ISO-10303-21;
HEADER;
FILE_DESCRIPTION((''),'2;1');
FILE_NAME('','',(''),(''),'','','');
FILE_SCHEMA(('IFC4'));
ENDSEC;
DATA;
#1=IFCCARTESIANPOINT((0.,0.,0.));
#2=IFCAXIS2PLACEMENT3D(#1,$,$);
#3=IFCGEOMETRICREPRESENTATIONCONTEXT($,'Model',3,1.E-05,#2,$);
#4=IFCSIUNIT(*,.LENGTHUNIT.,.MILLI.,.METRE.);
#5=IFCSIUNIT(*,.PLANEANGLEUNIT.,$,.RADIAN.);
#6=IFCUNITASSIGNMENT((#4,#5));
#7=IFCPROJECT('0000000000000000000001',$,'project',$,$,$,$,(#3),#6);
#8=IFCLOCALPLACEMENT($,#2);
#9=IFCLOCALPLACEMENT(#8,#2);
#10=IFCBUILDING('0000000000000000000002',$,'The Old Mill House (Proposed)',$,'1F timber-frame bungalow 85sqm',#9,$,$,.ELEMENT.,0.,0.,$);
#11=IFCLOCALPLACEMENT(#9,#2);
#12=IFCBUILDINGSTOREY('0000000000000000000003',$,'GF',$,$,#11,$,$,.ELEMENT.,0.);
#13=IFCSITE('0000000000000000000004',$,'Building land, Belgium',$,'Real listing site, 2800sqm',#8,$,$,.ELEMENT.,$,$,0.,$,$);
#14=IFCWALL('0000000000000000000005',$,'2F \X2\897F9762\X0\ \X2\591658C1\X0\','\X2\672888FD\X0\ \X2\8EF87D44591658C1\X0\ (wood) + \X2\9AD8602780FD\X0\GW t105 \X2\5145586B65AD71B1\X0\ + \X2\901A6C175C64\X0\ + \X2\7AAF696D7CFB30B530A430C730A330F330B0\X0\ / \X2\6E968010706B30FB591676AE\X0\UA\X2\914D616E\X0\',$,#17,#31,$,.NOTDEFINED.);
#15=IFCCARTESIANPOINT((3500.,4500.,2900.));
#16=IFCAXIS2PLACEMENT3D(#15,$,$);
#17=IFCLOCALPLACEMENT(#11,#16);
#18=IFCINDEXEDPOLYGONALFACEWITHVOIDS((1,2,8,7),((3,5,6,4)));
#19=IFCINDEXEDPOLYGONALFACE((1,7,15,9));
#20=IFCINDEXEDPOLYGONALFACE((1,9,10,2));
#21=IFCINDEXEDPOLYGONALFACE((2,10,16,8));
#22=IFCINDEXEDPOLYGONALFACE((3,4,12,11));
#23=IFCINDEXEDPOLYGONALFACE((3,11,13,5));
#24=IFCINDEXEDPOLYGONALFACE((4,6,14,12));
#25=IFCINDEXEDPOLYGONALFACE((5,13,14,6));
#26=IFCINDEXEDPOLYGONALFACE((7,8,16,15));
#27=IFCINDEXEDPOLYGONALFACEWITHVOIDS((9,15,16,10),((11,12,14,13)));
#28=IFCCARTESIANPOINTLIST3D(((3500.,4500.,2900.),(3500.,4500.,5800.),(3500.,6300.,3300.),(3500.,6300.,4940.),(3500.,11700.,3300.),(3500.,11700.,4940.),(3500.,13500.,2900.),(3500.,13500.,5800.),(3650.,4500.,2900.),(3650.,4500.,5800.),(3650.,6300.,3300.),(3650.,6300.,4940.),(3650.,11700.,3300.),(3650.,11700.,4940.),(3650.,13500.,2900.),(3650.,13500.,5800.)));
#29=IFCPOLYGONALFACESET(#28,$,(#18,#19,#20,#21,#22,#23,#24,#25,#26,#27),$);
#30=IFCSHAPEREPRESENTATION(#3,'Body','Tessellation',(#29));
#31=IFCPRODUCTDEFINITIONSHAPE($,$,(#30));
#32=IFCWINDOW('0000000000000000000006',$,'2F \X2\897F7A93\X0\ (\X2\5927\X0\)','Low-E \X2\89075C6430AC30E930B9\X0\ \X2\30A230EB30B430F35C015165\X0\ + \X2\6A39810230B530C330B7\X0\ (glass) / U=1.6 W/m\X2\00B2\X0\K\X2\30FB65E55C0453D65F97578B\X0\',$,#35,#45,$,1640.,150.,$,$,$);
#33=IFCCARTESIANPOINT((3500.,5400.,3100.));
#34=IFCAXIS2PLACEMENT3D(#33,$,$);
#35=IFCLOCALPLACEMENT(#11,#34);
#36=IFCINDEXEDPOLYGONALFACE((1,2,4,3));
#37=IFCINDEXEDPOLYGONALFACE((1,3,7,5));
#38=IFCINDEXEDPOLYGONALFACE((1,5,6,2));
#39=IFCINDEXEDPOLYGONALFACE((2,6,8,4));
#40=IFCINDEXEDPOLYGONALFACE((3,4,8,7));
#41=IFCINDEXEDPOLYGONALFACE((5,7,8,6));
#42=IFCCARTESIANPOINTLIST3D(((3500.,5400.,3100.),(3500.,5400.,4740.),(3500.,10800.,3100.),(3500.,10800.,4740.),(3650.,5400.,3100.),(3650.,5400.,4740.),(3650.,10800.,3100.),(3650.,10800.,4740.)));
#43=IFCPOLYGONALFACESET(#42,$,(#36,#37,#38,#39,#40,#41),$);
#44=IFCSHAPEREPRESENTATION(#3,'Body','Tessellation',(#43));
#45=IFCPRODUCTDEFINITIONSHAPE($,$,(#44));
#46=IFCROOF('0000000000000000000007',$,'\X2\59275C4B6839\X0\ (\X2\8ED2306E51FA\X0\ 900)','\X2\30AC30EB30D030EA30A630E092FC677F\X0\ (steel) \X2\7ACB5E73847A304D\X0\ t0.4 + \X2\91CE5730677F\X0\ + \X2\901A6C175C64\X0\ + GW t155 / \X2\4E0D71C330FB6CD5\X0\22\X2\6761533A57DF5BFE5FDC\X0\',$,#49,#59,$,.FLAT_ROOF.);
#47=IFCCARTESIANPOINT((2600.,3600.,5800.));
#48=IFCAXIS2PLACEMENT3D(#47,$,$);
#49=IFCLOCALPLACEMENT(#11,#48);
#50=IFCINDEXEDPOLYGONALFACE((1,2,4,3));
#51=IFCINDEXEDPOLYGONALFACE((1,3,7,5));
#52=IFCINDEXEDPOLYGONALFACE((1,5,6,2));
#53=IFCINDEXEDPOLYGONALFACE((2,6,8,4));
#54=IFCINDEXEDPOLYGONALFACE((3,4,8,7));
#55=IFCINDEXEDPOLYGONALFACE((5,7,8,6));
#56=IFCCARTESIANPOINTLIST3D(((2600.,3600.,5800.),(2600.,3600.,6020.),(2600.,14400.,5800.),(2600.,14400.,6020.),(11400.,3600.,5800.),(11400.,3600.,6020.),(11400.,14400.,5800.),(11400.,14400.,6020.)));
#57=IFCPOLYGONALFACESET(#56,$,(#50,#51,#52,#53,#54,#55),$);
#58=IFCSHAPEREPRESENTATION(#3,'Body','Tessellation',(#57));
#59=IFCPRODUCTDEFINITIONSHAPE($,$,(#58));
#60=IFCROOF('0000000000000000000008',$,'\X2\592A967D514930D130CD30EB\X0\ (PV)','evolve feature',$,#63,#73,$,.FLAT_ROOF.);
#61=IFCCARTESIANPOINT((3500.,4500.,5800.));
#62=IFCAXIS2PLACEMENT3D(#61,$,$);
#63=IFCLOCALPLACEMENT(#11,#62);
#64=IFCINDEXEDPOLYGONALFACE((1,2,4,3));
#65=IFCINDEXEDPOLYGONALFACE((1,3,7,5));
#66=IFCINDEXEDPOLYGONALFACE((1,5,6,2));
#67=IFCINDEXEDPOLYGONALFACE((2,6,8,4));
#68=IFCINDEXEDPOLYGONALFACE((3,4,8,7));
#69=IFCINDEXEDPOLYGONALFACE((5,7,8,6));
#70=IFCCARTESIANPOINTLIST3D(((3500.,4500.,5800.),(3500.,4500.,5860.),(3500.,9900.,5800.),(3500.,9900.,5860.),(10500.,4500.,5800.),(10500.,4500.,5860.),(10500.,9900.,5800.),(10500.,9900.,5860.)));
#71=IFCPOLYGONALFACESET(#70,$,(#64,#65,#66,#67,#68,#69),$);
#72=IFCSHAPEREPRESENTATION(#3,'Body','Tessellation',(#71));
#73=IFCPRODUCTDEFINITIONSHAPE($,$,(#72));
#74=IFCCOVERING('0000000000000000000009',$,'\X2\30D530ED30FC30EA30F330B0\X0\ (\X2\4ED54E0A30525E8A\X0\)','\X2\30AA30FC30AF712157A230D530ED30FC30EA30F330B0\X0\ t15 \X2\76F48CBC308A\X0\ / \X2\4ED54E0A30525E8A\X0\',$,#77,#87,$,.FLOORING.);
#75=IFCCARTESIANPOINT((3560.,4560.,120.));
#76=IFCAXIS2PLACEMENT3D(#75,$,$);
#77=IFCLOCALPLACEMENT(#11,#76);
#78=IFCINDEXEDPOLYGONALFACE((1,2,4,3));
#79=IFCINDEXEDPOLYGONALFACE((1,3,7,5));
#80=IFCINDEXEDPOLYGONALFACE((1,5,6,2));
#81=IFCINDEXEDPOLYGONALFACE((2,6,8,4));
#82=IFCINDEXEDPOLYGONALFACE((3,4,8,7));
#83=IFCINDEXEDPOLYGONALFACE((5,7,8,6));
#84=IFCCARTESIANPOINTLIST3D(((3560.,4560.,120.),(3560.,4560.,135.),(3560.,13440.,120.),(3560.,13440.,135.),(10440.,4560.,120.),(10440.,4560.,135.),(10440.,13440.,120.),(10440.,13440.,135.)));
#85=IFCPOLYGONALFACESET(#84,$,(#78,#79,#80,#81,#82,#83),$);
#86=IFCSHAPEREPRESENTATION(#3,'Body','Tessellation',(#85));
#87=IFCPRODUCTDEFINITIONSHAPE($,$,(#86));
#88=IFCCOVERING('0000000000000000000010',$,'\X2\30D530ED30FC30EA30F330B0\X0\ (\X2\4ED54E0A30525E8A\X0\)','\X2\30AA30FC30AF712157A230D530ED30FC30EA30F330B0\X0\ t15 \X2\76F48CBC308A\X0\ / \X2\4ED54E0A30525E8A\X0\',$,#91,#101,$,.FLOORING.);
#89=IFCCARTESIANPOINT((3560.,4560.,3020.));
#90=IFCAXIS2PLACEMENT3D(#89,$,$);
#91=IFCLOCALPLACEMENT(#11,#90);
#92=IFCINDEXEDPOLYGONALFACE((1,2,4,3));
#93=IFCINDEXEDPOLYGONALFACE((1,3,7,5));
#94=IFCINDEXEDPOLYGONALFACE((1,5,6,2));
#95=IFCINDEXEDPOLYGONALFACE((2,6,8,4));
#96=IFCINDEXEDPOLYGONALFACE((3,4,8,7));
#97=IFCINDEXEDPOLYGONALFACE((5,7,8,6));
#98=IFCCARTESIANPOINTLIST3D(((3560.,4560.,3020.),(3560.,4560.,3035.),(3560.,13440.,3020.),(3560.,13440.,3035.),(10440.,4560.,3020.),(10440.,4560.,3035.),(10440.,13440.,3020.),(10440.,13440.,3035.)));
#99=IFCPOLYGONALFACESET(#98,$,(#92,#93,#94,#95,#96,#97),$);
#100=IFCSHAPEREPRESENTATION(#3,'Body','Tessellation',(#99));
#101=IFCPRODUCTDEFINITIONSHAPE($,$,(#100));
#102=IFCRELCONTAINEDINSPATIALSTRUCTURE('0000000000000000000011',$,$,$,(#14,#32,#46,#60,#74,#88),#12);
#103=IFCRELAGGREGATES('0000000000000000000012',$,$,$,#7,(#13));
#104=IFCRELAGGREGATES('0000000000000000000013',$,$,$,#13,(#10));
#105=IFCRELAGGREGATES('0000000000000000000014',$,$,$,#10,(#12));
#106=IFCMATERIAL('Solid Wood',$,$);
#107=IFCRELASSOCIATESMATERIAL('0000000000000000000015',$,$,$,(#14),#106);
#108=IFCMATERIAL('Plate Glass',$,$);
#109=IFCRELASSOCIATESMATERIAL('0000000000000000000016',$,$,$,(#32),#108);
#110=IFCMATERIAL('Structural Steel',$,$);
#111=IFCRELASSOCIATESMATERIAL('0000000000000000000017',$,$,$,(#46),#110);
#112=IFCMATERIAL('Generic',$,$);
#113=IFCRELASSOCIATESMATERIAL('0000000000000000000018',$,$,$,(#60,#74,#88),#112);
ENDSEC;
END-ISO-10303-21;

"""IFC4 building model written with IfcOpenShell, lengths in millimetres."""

from ifc_helpers import new_model, si_unit, frame, frame_2d, origin, place, context, project, spatial, rectangle, extrude, material, element, fill, save


model = new_model("IFC4")

# Units and contexts
model_context = context("Model", 3, precision=1e-05, world=origin())
ifc_project = project(units=[si_unit("LENGTHUNIT", "METRE", prefix="MILLI"), si_unit("PLANEANGLEUNIT", "RADIAN")], contexts=[model_context])

# Site, building, storey
site_placement = place(None, origin())
site = spatial("IfcSite", under=ifc_project, at=site_placement, Name="Building land, Belgium", ObjectType="Real listing site, 2800sqm", CompositionType="ELEMENT", RefElevation=0.0)
building_placement = place(site_placement, origin())
building = spatial("IfcBuilding", under=site, at=building_placement, Name="The Old Mill House (Proposed)", ObjectType="1F timber-frame bungalow 85sqm", CompositionType="ELEMENT", ElevationOfRefHeight=0.0, ElevationOfTerrain=0.0)
storey_placement = place(building_placement, origin())
storey = spatial("IfcBuildingStorey", under=building, at=storey_placement, Name="GF", CompositionType="ELEMENT", Elevation=0.0)

# Shared definitions
ifc_material_1 = material(Name="Solid Wood")
ifc_material_2 = material(Name="Generic")

# Shared definitions
ifc_material_3 = material(Name="Plate Glass")

# Wall, opening, window
wall_1_placement = place(storey_placement, frame((3500.0, 4500.0, 2900.0)))
wall_1 = element("IfcWall", 1, at=wall_1_placement, inside=storey, material=ifc_material_1, Name="2F 西面 外壁", Description="木製 軸組外壁 (wood) + 高性能GW t105 充填断熱 + 通気層 + 窯業系サイディング / 準耐火・外皮UA配慮", PredefinedType="NOTDEFINED", context=model_context, shape_type="SweptSolid", body=[
    extrude(rectangle(XDim=150.0, YDim=9000.0, at=frame_2d((75.0, 4500.0))), frame((3500.0, 4500.0, 2900.0)), (0.0, 0.0, 1.0), 2900.0),
])
opening_1_placement = place(storey_placement, frame((3500.0, 5400.0, 3100.0)))
opening_1 = element("IfcOpeningElement", 2, at=opening_1_placement, cuts=wall_1, PredefinedType="NOTDEFINED", context=model_context, shape_type="SweptSolid", body=[
    extrude(rectangle(XDim=150.0, YDim=5400.0, at=frame_2d((75.0, 2700.0))), frame((3500.0, 5400.0, 3100.0)), (0.0, 0.0, 1.0), 1640.0),
])
window_1_placement = place(storey_placement, frame((3500.0, 5400.0, 3100.0)))
window_1 = element("IfcWindow", 3, at=window_1_placement, inside=storey, material=ifc_material_3, Name="2F 西窓 (大)", Description="Low-E 複層ガラス アルゴン封入 + 樹脂サッシ (glass) / U=1.6 W/m²K・日射取得型", OverallHeight=1640.0, OverallWidth=150.0, context=model_context, shape_type="SweptSolid", body=[
    extrude(rectangle(XDim=150.0, YDim=5400.0, at=frame_2d((75.0, 2700.0))), frame((3500.0, 5400.0, 3100.0)), (0.0, 0.0, 1.0), 1640.0),
])
fill(opening_1, window_1)

# Roofs
ifc_material_4 = material(Name="Structural Steel")
roof_1_placement = place(storey_placement, frame((2600.0, 3600.0, 5800.0)))
element("IfcRoof", 4, at=roof_1_placement, inside=storey, material=ifc_material_4, Name="大屋根 (軒の出 900)", Description="ガルバリウム鋼板 (steel) 立平葺き t0.4 + 野地板 + 通気層 + GW t155 / 不燃・法22条区域対応", PredefinedType="FLAT_ROOF", context=model_context, shape_type="SweptSolid", body=[
    extrude(rectangle(XDim=8800.0, YDim=10800.0, at=frame_2d((4400.0, 5400.0))), frame((2600.0, 3600.0, 5800.0)), (0.0, 0.0, 1.0), 220.0),
])
roof_2_placement = place(storey_placement, frame((3500.0, 4500.0, 5800.0)))
element("IfcRoof", 5, at=roof_2_placement, inside=storey, material=ifc_material_2, Name="太陽光パネル (PV)", Description="evolve feature", PredefinedType="FLAT_ROOF", context=model_context, shape_type="SweptSolid", body=[
    extrude(rectangle(XDim=7000.0, YDim=5400.0, at=frame_2d((3500.0, 2700.0))), frame((3500.0, 4500.0, 5800.0)), (0.0, 0.0, 1.0), 60.0),
])

# Coverings
covering_1_placement = place(storey_placement, frame((3560.0, 4560.0, 120.0)))
element("IfcCovering", 6, at=covering_1_placement, inside=storey, material=ifc_material_2, Name="フローリング (仕上げ床)", Description="オーク無垢フローリング t15 直貼り / 仕上げ床", PredefinedType="FLOORING", context=model_context, shape_type="SweptSolid", body=[
    extrude(rectangle(XDim=6880.0, YDim=8880.0, at=frame_2d((3440.0, 4440.0))), frame((3560.0, 4560.0, 120.0)), (0.0, 0.0, 1.0), 15.0),
])
covering_2_placement = place(storey_placement, frame((3560.0, 4560.0, 3020.0)))
element("IfcCovering", 7, at=covering_2_placement, inside=storey, material=ifc_material_2, Name="フローリング (仕上げ床)", Description="オーク無垢フローリング t15 直貼り / 仕上げ床", PredefinedType="FLOORING", context=model_context, shape_type="SweptSolid", body=[
    extrude(rectangle(XDim=6880.0, YDim=8880.0, at=frame_2d((3440.0, 4440.0))), frame((3560.0, 4560.0, 3020.0)), (0.0, 0.0, 1.0), 15.0),
])

save(model, "model.ifc")
